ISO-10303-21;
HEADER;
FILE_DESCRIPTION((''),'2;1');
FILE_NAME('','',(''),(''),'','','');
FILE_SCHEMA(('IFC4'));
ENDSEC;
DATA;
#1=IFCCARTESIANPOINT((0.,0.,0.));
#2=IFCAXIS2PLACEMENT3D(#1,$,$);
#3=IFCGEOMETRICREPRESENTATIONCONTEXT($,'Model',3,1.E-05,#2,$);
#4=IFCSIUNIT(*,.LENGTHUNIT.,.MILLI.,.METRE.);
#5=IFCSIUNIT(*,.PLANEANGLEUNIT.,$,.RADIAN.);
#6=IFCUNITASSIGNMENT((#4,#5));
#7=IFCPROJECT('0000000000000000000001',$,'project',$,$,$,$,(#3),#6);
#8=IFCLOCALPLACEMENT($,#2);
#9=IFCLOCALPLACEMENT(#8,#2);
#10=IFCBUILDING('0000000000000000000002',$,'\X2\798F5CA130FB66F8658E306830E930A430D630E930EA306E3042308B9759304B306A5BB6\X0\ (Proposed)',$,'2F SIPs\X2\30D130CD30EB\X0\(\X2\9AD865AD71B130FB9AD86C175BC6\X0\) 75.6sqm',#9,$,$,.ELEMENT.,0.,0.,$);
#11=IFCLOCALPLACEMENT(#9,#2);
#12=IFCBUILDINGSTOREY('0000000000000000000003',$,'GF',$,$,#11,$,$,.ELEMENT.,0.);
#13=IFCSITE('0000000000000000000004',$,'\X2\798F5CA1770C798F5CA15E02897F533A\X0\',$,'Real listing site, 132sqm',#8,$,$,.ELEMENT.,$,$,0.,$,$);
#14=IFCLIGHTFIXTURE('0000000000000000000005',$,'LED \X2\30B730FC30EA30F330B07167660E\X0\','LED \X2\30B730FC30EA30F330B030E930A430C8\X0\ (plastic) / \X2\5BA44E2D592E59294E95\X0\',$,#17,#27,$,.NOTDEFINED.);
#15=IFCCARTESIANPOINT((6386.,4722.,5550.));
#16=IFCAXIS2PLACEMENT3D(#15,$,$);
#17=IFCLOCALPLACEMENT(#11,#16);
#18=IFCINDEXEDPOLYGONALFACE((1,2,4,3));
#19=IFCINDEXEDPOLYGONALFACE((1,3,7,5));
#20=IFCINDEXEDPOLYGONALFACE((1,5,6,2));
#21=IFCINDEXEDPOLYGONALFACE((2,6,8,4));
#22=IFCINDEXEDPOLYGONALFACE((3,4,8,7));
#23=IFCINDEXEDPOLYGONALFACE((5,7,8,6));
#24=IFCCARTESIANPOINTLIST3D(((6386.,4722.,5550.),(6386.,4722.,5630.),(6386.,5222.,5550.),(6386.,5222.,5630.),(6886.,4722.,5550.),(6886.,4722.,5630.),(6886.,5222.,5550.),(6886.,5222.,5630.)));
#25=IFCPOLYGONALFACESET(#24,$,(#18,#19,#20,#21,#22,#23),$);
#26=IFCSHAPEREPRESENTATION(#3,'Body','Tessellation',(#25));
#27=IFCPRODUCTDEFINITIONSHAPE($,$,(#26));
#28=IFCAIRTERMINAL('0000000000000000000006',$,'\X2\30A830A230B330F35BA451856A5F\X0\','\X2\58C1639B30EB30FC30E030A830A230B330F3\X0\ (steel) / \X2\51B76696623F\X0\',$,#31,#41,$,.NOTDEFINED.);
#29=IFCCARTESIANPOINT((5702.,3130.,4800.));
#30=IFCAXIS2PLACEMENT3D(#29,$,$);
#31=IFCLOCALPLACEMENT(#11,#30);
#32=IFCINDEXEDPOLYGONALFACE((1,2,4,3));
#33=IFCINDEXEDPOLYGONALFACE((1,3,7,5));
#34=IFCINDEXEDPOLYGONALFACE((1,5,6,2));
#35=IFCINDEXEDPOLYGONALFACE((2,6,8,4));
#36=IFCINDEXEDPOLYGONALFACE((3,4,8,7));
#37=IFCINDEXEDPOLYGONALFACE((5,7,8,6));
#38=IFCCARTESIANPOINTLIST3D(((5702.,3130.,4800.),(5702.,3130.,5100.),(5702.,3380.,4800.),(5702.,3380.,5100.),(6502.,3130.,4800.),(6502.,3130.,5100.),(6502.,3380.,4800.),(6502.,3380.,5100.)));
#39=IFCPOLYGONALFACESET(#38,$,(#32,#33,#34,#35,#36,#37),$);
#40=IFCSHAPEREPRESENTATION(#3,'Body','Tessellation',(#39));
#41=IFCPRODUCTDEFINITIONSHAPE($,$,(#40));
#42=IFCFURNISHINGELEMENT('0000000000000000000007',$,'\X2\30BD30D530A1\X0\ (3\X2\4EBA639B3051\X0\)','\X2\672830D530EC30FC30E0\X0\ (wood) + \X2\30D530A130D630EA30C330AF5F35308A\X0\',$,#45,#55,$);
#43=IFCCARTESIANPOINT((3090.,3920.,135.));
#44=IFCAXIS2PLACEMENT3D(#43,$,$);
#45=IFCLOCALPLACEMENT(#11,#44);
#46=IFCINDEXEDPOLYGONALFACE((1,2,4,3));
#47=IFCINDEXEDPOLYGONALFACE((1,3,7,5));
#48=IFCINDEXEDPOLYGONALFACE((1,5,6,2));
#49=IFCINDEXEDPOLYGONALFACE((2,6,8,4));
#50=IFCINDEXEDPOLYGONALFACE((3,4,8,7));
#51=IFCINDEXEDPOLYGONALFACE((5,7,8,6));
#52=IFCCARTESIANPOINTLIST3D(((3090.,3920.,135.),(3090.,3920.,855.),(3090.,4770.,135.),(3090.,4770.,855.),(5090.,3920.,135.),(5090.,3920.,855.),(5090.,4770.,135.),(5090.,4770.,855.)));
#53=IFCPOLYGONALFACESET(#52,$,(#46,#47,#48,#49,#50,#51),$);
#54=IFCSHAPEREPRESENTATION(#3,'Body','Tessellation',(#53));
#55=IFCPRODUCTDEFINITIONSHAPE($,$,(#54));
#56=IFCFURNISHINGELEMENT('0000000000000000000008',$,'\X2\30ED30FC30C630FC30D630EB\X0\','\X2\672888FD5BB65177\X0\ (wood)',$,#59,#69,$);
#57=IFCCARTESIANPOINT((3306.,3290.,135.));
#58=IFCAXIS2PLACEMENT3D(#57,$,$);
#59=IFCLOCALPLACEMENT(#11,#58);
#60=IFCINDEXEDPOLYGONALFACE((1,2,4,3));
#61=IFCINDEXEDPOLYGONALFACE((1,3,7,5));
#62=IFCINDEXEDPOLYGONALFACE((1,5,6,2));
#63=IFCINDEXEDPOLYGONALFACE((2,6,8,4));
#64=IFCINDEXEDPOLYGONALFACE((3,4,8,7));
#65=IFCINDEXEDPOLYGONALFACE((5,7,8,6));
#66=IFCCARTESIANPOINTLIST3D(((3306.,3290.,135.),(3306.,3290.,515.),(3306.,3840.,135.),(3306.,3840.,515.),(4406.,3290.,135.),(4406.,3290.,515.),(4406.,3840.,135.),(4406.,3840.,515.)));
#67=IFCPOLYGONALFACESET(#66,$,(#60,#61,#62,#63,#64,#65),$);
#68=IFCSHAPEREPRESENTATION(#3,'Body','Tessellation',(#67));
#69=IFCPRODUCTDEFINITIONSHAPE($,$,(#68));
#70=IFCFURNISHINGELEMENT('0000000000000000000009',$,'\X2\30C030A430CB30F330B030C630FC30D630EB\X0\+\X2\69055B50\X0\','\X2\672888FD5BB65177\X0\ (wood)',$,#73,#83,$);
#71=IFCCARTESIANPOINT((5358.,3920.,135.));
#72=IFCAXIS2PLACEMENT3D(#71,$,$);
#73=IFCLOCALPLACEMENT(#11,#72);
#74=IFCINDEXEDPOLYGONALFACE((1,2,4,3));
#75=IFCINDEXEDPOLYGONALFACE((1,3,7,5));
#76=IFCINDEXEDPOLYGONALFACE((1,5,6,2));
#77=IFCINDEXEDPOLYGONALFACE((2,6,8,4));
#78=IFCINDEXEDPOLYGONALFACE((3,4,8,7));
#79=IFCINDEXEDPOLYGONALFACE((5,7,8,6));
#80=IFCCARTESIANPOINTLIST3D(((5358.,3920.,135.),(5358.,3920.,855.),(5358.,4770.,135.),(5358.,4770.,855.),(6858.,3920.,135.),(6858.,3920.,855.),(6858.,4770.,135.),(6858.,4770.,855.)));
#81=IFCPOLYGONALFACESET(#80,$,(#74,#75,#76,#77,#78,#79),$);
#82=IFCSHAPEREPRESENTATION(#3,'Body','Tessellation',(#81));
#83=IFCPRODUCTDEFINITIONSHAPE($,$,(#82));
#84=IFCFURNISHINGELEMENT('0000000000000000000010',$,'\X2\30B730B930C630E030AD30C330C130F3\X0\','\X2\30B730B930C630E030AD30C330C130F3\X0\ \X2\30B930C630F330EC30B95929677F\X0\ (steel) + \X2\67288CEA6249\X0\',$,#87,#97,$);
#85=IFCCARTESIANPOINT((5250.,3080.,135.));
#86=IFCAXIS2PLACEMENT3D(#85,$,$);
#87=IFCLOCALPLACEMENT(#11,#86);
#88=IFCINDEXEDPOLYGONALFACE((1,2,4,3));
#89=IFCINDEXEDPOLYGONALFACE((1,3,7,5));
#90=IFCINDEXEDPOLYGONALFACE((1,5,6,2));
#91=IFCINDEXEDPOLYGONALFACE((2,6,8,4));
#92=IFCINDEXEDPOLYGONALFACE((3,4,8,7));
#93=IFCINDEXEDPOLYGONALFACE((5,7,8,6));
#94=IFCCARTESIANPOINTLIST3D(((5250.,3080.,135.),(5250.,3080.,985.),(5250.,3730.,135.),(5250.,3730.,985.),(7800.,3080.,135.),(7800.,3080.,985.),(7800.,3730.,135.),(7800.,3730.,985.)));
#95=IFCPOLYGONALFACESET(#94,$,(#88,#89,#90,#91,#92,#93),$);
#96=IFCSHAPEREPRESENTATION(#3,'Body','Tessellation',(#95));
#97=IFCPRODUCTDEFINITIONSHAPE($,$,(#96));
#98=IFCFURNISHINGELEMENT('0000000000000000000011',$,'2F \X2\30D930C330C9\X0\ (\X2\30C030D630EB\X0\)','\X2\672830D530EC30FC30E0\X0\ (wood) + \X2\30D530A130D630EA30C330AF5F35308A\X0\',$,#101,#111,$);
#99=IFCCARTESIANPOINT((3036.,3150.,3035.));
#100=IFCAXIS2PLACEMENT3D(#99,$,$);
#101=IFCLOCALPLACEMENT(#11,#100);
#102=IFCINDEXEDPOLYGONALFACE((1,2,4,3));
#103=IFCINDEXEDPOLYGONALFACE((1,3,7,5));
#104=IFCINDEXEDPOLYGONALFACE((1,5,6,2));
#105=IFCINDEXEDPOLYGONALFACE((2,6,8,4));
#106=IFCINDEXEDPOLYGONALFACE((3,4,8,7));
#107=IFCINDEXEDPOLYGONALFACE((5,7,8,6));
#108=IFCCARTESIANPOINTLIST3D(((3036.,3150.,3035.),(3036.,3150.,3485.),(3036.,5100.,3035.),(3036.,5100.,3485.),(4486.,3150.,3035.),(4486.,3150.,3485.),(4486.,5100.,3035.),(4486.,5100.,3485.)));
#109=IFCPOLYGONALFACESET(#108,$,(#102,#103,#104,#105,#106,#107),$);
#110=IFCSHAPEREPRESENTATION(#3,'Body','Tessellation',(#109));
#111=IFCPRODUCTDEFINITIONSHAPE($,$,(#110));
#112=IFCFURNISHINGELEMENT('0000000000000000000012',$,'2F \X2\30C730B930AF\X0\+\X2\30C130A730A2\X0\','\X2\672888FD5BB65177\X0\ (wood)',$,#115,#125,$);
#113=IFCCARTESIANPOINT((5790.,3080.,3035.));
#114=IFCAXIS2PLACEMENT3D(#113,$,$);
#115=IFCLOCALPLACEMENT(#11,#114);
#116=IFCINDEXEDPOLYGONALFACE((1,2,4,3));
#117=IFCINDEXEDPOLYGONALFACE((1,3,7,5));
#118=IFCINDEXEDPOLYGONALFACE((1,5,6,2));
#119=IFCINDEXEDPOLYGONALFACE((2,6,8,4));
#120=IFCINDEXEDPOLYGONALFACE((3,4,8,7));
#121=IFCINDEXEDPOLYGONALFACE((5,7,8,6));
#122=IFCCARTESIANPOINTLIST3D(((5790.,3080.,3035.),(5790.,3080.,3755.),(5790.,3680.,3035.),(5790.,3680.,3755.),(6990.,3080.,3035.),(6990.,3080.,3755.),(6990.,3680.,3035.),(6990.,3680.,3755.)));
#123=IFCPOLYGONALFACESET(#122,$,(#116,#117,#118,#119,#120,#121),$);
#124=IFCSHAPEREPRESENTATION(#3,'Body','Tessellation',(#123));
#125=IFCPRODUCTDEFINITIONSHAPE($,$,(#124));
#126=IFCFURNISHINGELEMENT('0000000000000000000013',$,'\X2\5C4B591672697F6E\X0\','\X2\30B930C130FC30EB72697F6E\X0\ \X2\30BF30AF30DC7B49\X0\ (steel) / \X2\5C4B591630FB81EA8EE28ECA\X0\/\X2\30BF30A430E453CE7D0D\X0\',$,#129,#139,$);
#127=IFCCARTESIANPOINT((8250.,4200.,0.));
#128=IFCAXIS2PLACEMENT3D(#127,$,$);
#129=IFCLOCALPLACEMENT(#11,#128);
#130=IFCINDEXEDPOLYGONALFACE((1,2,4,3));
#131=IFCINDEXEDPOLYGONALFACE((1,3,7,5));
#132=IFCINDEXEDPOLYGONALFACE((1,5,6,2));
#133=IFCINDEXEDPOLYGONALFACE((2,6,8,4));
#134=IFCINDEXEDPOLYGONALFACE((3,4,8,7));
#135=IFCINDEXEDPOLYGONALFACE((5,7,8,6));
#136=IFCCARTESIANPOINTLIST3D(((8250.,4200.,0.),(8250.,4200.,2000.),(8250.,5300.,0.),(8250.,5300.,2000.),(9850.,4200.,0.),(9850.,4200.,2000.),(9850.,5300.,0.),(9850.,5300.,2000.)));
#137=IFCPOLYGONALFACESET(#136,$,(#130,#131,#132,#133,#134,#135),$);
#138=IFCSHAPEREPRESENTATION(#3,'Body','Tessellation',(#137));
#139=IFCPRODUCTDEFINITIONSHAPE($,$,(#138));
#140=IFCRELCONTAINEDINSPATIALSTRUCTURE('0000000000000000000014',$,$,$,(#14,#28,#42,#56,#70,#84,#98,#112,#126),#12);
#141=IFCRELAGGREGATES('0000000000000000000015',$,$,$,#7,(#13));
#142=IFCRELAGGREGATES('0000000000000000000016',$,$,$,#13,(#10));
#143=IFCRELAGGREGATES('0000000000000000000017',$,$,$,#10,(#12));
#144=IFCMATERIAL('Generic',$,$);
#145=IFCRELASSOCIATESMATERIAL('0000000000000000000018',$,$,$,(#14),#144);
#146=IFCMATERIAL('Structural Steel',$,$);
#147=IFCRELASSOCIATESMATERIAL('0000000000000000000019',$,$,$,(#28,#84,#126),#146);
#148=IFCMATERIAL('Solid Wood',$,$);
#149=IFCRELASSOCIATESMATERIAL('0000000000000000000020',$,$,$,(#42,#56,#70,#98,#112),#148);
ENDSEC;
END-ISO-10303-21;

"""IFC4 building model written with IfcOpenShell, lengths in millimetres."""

from ifc_helpers import new_model, si_unit, frame, frame_2d, origin, place, context, project, spatial, rectangle, extrude, material, element, save


model = new_model("IFC4")

# Units and contexts
model_context = context("Model", 3, precision=1e-05, world=origin())
ifc_project = project(units=[si_unit("LENGTHUNIT", "METRE", prefix="MILLI"), si_unit("PLANEANGLEUNIT", "RADIAN")], contexts=[model_context])

# Site, building, storey
site_placement = place(None, origin())
site = spatial("IfcSite", under=ifc_project, at=site_placement, Name="福岡県福岡市西区", ObjectType="Real listing site, 132sqm", CompositionType="ELEMENT", RefElevation=0.0)
building_placement = place(site_placement, origin())
building = spatial("IfcBuilding", under=site, at=building_placement, Name="福岡・書斎とライブラリのある静かな家 (Proposed)", ObjectType="2F SIPsパネル(高断熱・高気密) 75.6sqm", CompositionType="ELEMENT", ElevationOfRefHeight=0.0, ElevationOfTerrain=0.0)
storey_placement = place(building_placement, origin())
storey = spatial("IfcBuildingStorey", under=building, at=storey_placement, Name="GF", CompositionType="ELEMENT", Elevation=0.0)

# Shared definitions
ifc_material_1 = material(Name="Solid Wood")

# Shared definitions
ifc_material_2 = material(Name="Generic")

# Shared definitions
ifc_material_3 = material(Name="Structural Steel")

# Light fixture
light_fixture_placement = place(storey_placement, frame((6386.0, 4722.0, 5550.0)))
element("IfcLightFixture", 1, at=light_fixture_placement, inside=storey, material=ifc_material_2, Name="LED シーリング照明", Description="LED シーリングライト (plastic) / 室中央天井", PredefinedType="NOTDEFINED", context=model_context, shape_type="SweptSolid", body=[
    extrude(rectangle(XDim=500.0, YDim=500.0, at=frame_2d((250.0, 250.0))), frame((6386.0, 4722.0, 5550.0)), (0.0, 0.0, 1.0), 80.0),
])

# Air terminal
air_terminal_1_placement = place(storey_placement, frame((5702.0, 3130.0, 4800.0)))
element("IfcAirTerminal", 2, at=air_terminal_1_placement, inside=storey, material=ifc_material_3, Name="エアコン室内機", Description="壁掛ルームエアコン (steel) / 冷暖房", PredefinedType="NOTDEFINED", context=model_context, shape_type="SweptSolid", body=[
    extrude(rectangle(XDim=800.0, YDim=250.0, at=frame_2d((400.0, 125.0))), frame((5702.0, 3130.0, 4800.0)), (0.0, 0.0, 1.0), 300.0),
])

# Furnishing elements
furnishing_1_placement = place(storey_placement, frame((3090.0, 3920.0, 135.0)))
element("IfcFurnishingElement", 3, at=furnishing_1_placement, inside=storey, material=ifc_material_1, Name="ソファ (3人掛け)", Description="木フレーム (wood) + ファブリック張り", context=model_context, shape_type="SweptSolid", body=[
    extrude(rectangle(XDim=2000.0, YDim=850.0, at=frame_2d((1000.0, 425.0))), frame((3090.0, 3920.0, 135.0)), (0.0, 0.0, 1.0), 720.0),
])
furnishing_2_placement = place(storey_placement, frame((3306.0, 3290.0, 135.0)))
element("IfcFurnishingElement", 4, at=furnishing_2_placement, inside=storey, material=ifc_material_1, Name="ローテーブル", Description="木製家具 (wood)", context=model_context, shape_type="SweptSolid", body=[
    extrude(rectangle(XDim=1100.0, YDim=550.0, at=frame_2d((550.0, 275.0))), frame((3306.0, 3290.0, 135.0)), (0.0, 0.0, 1.0), 380.0),
])
furnishing_3_placement = place(storey_placement, frame((5358.0, 3920.0, 135.0)))
element("IfcFurnishingElement", 5, at=furnishing_3_placement, inside=storey, material=ifc_material_1, Name="ダイニングテーブル+椅子", Description="木製家具 (wood)", context=model_context, shape_type="SweptSolid", body=[
    extrude(rectangle(XDim=1500.0, YDim=850.0, at=frame_2d((750.0, 425.0))), frame((5358.0, 3920.0, 135.0)), (0.0, 0.0, 1.0), 720.0),
])
furnishing_4_placement = place(storey_placement, frame((5250.0, 3080.0, 135.0)))
element("IfcFurnishingElement", 6, at=furnishing_4_placement, inside=storey, material=ifc_material_3, Name="システムキッチン", Description="システムキッチン ステンレス天板 (steel) + 木質扉", context=model_context, shape_type="SweptSolid", body=[
    extrude(rectangle(XDim=2550.0, YDim=650.0, at=frame_2d((1275.0, 325.0))), frame((5250.0, 3080.0, 135.0)), (0.0, 0.0, 1.0), 850.0),
])
furnishing_5_placement = place(storey_placement, frame((3036.0, 3150.0, 3035.0)))
element("IfcFurnishingElement", 7, at=furnishing_5_placement, inside=storey, material=ifc_material_1, Name="2F ベッド (ダブル)", Description="木フレーム (wood) + ファブリック張り", context=model_context, shape_type="SweptSolid", body=[
    extrude(rectangle(XDim=1450.0, YDim=1950.0, at=frame_2d((725.0, 975.0))), frame((3036.0, 3150.0, 3035.0)), (0.0, 0.0, 1.0), 450.0),
])
furnishing_6_placement = place(storey_placement, frame((5790.0, 3080.0, 3035.0)))
element("IfcFurnishingElement", 8, at=furnishing_6_placement, inside=storey, material=ifc_material_1, Name="2F デスク+チェア", Description="木製家具 (wood)", context=model_context, shape_type="SweptSolid", body=[
    extrude(rectangle(XDim=1200.0, YDim=600.0, at=frame_2d((600.0, 300.0))), frame((5790.0, 3080.0, 3035.0)), (0.0, 0.0, 1.0), 720.0),
])
furnishing_7_placement = place(storey_placement, frame((8250.0, 4200.0, 0.0)))
element("IfcFurnishingElement", 9, at=furnishing_7_placement, inside=storey, material=ifc_material_3, Name="屋外物置", Description="スチール物置 タクボ等 (steel) / 屋外・自転車/タイヤ収納", context=model_context, shape_type="SweptSolid", body=[
    extrude(rectangle(XDim=1600.0, YDim=1100.0, at=frame_2d((800.0, 550.0))), frame((8250.0, 4200.0, 0.0)), (0.0, 0.0, 1.0), 2000.0),
])

save(model, "model.ifc")
